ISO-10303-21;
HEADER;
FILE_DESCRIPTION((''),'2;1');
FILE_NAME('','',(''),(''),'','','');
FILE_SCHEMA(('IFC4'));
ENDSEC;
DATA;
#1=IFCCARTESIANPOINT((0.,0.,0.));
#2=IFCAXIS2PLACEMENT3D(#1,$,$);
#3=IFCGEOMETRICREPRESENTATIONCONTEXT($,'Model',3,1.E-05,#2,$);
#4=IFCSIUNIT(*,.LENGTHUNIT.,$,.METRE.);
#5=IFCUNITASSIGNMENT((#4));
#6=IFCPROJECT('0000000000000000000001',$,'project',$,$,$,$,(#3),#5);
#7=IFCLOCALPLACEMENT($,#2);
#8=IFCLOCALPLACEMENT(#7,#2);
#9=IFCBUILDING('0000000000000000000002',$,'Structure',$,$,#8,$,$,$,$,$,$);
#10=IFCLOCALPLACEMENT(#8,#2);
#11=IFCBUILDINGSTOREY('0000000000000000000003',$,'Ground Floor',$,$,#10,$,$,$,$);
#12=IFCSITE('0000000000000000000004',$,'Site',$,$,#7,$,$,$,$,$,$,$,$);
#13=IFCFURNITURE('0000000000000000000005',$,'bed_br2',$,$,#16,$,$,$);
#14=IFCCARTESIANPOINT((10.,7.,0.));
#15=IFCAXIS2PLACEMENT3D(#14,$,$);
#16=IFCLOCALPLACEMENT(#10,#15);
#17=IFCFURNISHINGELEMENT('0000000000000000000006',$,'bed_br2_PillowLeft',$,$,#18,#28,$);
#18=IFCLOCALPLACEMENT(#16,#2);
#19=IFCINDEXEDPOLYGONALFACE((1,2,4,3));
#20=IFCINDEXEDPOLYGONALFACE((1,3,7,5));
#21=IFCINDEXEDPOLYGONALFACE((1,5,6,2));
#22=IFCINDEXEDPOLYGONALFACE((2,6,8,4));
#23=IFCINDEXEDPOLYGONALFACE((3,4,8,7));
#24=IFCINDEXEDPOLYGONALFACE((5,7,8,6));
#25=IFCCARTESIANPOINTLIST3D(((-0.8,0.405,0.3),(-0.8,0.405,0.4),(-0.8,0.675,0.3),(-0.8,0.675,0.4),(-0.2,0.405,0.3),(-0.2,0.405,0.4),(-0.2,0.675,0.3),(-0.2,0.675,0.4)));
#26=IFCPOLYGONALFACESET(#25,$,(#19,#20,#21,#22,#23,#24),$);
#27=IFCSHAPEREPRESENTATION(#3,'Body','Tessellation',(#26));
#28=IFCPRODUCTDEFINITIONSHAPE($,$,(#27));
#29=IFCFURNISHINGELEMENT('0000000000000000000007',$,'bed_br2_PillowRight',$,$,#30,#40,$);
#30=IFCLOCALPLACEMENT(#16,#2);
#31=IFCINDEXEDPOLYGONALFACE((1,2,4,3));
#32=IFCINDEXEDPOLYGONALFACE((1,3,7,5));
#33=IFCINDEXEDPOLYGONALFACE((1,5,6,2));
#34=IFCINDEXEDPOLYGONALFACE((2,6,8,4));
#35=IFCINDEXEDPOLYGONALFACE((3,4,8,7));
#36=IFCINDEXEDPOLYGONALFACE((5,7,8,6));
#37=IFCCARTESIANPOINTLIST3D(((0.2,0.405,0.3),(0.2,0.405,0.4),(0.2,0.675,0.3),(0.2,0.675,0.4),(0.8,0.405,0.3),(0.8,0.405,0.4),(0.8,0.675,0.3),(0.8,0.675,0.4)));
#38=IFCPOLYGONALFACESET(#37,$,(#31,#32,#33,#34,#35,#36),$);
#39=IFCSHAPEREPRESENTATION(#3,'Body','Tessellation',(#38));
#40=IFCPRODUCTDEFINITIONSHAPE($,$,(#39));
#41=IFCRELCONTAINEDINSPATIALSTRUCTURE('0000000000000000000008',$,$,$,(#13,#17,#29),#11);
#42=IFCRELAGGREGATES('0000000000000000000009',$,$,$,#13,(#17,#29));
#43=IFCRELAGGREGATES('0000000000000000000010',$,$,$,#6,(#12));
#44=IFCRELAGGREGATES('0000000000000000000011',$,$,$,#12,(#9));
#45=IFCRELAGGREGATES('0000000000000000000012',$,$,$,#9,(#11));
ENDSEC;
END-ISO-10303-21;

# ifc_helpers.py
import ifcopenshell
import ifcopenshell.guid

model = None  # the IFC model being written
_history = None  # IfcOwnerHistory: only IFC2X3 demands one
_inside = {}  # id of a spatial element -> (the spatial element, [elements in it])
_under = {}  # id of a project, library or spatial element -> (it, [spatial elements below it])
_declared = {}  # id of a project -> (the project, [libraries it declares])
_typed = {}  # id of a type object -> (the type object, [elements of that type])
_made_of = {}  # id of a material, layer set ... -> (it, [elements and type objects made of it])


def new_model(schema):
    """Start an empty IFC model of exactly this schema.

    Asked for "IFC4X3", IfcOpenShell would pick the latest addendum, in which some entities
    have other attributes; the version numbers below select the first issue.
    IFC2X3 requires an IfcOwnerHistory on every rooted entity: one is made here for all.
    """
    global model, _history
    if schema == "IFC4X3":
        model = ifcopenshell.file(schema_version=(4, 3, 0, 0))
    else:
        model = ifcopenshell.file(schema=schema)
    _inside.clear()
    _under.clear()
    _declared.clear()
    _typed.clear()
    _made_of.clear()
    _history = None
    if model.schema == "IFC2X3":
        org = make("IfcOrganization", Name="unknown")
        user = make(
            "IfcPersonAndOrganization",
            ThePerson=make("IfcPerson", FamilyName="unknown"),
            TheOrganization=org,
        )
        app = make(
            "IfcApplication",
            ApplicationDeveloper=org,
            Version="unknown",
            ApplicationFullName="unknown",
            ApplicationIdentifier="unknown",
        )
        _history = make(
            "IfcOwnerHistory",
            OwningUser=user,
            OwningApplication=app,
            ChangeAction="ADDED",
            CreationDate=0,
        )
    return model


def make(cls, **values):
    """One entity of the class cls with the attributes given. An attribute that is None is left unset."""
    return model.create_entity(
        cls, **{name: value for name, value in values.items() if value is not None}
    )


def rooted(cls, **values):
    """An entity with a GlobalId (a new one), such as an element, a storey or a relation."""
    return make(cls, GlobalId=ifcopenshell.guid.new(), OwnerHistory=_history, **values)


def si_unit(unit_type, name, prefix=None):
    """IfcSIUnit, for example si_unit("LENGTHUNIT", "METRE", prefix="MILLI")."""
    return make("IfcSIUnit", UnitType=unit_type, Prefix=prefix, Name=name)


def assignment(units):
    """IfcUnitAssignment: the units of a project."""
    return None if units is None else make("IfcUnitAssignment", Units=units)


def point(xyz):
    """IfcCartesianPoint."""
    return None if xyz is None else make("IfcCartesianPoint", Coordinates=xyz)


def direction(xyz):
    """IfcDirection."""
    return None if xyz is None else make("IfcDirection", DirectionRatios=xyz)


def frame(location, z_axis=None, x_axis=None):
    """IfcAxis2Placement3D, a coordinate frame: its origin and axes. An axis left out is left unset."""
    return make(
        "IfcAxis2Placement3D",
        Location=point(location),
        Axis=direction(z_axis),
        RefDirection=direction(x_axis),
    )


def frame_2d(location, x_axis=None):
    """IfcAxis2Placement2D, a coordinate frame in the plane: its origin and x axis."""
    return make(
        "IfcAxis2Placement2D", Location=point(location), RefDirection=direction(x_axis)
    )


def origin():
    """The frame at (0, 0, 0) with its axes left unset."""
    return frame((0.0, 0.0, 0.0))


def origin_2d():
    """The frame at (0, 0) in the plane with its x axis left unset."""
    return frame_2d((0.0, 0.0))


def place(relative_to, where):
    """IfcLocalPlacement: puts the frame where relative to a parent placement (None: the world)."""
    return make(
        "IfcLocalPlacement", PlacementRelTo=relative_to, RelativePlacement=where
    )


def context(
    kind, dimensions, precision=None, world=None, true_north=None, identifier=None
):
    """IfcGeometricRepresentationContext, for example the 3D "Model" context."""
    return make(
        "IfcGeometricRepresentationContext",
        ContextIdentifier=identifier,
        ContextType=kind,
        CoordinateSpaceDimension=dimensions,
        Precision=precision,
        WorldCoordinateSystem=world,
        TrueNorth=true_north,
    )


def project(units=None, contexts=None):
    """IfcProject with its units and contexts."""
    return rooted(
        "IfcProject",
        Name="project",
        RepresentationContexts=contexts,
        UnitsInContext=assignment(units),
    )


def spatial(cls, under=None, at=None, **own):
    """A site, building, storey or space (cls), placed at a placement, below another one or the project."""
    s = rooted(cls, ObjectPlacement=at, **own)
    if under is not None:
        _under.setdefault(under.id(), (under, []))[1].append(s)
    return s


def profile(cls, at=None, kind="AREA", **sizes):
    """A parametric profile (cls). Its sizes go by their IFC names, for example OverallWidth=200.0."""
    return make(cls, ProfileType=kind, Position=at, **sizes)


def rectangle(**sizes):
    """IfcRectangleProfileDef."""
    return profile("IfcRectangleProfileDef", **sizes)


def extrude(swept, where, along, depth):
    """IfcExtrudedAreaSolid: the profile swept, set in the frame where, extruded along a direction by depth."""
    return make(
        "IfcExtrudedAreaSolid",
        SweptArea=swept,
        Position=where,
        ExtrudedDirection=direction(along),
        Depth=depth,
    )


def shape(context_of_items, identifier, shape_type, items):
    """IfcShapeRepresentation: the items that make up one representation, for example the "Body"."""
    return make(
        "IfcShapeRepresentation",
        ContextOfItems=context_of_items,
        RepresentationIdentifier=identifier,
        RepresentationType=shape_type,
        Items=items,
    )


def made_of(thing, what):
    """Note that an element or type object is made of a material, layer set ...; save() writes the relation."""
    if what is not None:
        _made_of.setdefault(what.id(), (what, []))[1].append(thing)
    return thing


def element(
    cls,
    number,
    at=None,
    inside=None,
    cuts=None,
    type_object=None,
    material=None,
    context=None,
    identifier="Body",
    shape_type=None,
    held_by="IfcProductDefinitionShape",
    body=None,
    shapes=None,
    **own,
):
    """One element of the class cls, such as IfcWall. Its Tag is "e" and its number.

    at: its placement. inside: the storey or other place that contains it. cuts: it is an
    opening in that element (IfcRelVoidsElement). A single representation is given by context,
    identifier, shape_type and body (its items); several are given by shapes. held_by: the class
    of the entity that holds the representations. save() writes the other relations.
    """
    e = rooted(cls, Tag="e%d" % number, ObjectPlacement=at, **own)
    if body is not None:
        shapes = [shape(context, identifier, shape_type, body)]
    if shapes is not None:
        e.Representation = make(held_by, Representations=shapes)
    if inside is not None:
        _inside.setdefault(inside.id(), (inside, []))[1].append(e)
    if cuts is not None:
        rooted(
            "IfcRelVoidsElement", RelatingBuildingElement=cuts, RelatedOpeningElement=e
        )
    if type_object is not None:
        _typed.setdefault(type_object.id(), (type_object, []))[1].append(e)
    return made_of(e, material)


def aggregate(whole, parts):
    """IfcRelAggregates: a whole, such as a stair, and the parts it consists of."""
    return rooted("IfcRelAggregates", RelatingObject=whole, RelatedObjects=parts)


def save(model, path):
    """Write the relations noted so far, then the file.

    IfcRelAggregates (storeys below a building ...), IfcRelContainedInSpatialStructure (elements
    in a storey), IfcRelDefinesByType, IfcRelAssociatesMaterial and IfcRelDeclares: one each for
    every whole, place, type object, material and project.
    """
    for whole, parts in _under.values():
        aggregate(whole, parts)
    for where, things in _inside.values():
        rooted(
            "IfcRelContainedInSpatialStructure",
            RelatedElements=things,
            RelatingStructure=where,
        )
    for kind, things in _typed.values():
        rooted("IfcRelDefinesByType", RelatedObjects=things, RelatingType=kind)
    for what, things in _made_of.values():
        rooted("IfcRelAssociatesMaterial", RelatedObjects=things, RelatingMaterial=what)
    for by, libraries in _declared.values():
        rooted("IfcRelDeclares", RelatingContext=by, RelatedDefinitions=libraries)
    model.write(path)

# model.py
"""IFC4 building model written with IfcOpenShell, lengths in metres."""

from ifc_helpers import new_model, si_unit, frame, origin, origin_2d, place, context, project, spatial, rectangle, extrude, element, aggregate, save


model = new_model("IFC4")

# Units and contexts
model_context = context("Model", 3, precision=1e-05, world=origin())
ifc_project = project(units=[si_unit("LENGTHUNIT", "METRE")], contexts=[model_context])

# Site, building, storey
site_placement = place(None, origin())
site = spatial("IfcSite", under=ifc_project, at=site_placement, Name="Site")
building_placement = place(site_placement, origin())
building = spatial("IfcBuilding", under=site, at=building_placement, Name="Structure")
storey_placement = place(building_placement, origin())
storey = spatial("IfcBuildingStorey", under=building, at=storey_placement, Name="Ground Floor")

# Furniture, furnishing elements
furniture_1_placement = place(storey_placement, frame((10.0, 7.0, 0.0)))
furniture_1 = element("IfcFurniture", 1, at=furniture_1_placement, inside=storey, Name="bed_br2")
furnishing_1_placement = place(furniture_1_placement, origin())
furnishing_1 = element("IfcFurnishingElement", 2, at=furnishing_1_placement, inside=storey, Name="bed_br2_PillowLeft", context=model_context, shape_type="SweptSolid", body=[
    extrude(rectangle(XDim=0.6, YDim=0.27, at=origin_2d()), frame((-0.5, 0.54, 0.3)), (0.0, 0.0, 1.0), 0.1),
])
furnishing_2_placement = place(furniture_1_placement, origin())
furnishing_2 = element("IfcFurnishingElement", 3, at=furnishing_2_placement, inside=storey, Name="bed_br2_PillowRight", context=model_context, shape_type="SweptSolid", body=[
    extrude(rectangle(XDim=0.6, YDim=0.27, at=origin_2d()), frame((0.5, 0.54, 0.3)), (0.0, 0.0, 1.0), 0.1),
])
aggregate(furniture_1, [furnishing_1, furnishing_2])

save(model, "model.ifc")
